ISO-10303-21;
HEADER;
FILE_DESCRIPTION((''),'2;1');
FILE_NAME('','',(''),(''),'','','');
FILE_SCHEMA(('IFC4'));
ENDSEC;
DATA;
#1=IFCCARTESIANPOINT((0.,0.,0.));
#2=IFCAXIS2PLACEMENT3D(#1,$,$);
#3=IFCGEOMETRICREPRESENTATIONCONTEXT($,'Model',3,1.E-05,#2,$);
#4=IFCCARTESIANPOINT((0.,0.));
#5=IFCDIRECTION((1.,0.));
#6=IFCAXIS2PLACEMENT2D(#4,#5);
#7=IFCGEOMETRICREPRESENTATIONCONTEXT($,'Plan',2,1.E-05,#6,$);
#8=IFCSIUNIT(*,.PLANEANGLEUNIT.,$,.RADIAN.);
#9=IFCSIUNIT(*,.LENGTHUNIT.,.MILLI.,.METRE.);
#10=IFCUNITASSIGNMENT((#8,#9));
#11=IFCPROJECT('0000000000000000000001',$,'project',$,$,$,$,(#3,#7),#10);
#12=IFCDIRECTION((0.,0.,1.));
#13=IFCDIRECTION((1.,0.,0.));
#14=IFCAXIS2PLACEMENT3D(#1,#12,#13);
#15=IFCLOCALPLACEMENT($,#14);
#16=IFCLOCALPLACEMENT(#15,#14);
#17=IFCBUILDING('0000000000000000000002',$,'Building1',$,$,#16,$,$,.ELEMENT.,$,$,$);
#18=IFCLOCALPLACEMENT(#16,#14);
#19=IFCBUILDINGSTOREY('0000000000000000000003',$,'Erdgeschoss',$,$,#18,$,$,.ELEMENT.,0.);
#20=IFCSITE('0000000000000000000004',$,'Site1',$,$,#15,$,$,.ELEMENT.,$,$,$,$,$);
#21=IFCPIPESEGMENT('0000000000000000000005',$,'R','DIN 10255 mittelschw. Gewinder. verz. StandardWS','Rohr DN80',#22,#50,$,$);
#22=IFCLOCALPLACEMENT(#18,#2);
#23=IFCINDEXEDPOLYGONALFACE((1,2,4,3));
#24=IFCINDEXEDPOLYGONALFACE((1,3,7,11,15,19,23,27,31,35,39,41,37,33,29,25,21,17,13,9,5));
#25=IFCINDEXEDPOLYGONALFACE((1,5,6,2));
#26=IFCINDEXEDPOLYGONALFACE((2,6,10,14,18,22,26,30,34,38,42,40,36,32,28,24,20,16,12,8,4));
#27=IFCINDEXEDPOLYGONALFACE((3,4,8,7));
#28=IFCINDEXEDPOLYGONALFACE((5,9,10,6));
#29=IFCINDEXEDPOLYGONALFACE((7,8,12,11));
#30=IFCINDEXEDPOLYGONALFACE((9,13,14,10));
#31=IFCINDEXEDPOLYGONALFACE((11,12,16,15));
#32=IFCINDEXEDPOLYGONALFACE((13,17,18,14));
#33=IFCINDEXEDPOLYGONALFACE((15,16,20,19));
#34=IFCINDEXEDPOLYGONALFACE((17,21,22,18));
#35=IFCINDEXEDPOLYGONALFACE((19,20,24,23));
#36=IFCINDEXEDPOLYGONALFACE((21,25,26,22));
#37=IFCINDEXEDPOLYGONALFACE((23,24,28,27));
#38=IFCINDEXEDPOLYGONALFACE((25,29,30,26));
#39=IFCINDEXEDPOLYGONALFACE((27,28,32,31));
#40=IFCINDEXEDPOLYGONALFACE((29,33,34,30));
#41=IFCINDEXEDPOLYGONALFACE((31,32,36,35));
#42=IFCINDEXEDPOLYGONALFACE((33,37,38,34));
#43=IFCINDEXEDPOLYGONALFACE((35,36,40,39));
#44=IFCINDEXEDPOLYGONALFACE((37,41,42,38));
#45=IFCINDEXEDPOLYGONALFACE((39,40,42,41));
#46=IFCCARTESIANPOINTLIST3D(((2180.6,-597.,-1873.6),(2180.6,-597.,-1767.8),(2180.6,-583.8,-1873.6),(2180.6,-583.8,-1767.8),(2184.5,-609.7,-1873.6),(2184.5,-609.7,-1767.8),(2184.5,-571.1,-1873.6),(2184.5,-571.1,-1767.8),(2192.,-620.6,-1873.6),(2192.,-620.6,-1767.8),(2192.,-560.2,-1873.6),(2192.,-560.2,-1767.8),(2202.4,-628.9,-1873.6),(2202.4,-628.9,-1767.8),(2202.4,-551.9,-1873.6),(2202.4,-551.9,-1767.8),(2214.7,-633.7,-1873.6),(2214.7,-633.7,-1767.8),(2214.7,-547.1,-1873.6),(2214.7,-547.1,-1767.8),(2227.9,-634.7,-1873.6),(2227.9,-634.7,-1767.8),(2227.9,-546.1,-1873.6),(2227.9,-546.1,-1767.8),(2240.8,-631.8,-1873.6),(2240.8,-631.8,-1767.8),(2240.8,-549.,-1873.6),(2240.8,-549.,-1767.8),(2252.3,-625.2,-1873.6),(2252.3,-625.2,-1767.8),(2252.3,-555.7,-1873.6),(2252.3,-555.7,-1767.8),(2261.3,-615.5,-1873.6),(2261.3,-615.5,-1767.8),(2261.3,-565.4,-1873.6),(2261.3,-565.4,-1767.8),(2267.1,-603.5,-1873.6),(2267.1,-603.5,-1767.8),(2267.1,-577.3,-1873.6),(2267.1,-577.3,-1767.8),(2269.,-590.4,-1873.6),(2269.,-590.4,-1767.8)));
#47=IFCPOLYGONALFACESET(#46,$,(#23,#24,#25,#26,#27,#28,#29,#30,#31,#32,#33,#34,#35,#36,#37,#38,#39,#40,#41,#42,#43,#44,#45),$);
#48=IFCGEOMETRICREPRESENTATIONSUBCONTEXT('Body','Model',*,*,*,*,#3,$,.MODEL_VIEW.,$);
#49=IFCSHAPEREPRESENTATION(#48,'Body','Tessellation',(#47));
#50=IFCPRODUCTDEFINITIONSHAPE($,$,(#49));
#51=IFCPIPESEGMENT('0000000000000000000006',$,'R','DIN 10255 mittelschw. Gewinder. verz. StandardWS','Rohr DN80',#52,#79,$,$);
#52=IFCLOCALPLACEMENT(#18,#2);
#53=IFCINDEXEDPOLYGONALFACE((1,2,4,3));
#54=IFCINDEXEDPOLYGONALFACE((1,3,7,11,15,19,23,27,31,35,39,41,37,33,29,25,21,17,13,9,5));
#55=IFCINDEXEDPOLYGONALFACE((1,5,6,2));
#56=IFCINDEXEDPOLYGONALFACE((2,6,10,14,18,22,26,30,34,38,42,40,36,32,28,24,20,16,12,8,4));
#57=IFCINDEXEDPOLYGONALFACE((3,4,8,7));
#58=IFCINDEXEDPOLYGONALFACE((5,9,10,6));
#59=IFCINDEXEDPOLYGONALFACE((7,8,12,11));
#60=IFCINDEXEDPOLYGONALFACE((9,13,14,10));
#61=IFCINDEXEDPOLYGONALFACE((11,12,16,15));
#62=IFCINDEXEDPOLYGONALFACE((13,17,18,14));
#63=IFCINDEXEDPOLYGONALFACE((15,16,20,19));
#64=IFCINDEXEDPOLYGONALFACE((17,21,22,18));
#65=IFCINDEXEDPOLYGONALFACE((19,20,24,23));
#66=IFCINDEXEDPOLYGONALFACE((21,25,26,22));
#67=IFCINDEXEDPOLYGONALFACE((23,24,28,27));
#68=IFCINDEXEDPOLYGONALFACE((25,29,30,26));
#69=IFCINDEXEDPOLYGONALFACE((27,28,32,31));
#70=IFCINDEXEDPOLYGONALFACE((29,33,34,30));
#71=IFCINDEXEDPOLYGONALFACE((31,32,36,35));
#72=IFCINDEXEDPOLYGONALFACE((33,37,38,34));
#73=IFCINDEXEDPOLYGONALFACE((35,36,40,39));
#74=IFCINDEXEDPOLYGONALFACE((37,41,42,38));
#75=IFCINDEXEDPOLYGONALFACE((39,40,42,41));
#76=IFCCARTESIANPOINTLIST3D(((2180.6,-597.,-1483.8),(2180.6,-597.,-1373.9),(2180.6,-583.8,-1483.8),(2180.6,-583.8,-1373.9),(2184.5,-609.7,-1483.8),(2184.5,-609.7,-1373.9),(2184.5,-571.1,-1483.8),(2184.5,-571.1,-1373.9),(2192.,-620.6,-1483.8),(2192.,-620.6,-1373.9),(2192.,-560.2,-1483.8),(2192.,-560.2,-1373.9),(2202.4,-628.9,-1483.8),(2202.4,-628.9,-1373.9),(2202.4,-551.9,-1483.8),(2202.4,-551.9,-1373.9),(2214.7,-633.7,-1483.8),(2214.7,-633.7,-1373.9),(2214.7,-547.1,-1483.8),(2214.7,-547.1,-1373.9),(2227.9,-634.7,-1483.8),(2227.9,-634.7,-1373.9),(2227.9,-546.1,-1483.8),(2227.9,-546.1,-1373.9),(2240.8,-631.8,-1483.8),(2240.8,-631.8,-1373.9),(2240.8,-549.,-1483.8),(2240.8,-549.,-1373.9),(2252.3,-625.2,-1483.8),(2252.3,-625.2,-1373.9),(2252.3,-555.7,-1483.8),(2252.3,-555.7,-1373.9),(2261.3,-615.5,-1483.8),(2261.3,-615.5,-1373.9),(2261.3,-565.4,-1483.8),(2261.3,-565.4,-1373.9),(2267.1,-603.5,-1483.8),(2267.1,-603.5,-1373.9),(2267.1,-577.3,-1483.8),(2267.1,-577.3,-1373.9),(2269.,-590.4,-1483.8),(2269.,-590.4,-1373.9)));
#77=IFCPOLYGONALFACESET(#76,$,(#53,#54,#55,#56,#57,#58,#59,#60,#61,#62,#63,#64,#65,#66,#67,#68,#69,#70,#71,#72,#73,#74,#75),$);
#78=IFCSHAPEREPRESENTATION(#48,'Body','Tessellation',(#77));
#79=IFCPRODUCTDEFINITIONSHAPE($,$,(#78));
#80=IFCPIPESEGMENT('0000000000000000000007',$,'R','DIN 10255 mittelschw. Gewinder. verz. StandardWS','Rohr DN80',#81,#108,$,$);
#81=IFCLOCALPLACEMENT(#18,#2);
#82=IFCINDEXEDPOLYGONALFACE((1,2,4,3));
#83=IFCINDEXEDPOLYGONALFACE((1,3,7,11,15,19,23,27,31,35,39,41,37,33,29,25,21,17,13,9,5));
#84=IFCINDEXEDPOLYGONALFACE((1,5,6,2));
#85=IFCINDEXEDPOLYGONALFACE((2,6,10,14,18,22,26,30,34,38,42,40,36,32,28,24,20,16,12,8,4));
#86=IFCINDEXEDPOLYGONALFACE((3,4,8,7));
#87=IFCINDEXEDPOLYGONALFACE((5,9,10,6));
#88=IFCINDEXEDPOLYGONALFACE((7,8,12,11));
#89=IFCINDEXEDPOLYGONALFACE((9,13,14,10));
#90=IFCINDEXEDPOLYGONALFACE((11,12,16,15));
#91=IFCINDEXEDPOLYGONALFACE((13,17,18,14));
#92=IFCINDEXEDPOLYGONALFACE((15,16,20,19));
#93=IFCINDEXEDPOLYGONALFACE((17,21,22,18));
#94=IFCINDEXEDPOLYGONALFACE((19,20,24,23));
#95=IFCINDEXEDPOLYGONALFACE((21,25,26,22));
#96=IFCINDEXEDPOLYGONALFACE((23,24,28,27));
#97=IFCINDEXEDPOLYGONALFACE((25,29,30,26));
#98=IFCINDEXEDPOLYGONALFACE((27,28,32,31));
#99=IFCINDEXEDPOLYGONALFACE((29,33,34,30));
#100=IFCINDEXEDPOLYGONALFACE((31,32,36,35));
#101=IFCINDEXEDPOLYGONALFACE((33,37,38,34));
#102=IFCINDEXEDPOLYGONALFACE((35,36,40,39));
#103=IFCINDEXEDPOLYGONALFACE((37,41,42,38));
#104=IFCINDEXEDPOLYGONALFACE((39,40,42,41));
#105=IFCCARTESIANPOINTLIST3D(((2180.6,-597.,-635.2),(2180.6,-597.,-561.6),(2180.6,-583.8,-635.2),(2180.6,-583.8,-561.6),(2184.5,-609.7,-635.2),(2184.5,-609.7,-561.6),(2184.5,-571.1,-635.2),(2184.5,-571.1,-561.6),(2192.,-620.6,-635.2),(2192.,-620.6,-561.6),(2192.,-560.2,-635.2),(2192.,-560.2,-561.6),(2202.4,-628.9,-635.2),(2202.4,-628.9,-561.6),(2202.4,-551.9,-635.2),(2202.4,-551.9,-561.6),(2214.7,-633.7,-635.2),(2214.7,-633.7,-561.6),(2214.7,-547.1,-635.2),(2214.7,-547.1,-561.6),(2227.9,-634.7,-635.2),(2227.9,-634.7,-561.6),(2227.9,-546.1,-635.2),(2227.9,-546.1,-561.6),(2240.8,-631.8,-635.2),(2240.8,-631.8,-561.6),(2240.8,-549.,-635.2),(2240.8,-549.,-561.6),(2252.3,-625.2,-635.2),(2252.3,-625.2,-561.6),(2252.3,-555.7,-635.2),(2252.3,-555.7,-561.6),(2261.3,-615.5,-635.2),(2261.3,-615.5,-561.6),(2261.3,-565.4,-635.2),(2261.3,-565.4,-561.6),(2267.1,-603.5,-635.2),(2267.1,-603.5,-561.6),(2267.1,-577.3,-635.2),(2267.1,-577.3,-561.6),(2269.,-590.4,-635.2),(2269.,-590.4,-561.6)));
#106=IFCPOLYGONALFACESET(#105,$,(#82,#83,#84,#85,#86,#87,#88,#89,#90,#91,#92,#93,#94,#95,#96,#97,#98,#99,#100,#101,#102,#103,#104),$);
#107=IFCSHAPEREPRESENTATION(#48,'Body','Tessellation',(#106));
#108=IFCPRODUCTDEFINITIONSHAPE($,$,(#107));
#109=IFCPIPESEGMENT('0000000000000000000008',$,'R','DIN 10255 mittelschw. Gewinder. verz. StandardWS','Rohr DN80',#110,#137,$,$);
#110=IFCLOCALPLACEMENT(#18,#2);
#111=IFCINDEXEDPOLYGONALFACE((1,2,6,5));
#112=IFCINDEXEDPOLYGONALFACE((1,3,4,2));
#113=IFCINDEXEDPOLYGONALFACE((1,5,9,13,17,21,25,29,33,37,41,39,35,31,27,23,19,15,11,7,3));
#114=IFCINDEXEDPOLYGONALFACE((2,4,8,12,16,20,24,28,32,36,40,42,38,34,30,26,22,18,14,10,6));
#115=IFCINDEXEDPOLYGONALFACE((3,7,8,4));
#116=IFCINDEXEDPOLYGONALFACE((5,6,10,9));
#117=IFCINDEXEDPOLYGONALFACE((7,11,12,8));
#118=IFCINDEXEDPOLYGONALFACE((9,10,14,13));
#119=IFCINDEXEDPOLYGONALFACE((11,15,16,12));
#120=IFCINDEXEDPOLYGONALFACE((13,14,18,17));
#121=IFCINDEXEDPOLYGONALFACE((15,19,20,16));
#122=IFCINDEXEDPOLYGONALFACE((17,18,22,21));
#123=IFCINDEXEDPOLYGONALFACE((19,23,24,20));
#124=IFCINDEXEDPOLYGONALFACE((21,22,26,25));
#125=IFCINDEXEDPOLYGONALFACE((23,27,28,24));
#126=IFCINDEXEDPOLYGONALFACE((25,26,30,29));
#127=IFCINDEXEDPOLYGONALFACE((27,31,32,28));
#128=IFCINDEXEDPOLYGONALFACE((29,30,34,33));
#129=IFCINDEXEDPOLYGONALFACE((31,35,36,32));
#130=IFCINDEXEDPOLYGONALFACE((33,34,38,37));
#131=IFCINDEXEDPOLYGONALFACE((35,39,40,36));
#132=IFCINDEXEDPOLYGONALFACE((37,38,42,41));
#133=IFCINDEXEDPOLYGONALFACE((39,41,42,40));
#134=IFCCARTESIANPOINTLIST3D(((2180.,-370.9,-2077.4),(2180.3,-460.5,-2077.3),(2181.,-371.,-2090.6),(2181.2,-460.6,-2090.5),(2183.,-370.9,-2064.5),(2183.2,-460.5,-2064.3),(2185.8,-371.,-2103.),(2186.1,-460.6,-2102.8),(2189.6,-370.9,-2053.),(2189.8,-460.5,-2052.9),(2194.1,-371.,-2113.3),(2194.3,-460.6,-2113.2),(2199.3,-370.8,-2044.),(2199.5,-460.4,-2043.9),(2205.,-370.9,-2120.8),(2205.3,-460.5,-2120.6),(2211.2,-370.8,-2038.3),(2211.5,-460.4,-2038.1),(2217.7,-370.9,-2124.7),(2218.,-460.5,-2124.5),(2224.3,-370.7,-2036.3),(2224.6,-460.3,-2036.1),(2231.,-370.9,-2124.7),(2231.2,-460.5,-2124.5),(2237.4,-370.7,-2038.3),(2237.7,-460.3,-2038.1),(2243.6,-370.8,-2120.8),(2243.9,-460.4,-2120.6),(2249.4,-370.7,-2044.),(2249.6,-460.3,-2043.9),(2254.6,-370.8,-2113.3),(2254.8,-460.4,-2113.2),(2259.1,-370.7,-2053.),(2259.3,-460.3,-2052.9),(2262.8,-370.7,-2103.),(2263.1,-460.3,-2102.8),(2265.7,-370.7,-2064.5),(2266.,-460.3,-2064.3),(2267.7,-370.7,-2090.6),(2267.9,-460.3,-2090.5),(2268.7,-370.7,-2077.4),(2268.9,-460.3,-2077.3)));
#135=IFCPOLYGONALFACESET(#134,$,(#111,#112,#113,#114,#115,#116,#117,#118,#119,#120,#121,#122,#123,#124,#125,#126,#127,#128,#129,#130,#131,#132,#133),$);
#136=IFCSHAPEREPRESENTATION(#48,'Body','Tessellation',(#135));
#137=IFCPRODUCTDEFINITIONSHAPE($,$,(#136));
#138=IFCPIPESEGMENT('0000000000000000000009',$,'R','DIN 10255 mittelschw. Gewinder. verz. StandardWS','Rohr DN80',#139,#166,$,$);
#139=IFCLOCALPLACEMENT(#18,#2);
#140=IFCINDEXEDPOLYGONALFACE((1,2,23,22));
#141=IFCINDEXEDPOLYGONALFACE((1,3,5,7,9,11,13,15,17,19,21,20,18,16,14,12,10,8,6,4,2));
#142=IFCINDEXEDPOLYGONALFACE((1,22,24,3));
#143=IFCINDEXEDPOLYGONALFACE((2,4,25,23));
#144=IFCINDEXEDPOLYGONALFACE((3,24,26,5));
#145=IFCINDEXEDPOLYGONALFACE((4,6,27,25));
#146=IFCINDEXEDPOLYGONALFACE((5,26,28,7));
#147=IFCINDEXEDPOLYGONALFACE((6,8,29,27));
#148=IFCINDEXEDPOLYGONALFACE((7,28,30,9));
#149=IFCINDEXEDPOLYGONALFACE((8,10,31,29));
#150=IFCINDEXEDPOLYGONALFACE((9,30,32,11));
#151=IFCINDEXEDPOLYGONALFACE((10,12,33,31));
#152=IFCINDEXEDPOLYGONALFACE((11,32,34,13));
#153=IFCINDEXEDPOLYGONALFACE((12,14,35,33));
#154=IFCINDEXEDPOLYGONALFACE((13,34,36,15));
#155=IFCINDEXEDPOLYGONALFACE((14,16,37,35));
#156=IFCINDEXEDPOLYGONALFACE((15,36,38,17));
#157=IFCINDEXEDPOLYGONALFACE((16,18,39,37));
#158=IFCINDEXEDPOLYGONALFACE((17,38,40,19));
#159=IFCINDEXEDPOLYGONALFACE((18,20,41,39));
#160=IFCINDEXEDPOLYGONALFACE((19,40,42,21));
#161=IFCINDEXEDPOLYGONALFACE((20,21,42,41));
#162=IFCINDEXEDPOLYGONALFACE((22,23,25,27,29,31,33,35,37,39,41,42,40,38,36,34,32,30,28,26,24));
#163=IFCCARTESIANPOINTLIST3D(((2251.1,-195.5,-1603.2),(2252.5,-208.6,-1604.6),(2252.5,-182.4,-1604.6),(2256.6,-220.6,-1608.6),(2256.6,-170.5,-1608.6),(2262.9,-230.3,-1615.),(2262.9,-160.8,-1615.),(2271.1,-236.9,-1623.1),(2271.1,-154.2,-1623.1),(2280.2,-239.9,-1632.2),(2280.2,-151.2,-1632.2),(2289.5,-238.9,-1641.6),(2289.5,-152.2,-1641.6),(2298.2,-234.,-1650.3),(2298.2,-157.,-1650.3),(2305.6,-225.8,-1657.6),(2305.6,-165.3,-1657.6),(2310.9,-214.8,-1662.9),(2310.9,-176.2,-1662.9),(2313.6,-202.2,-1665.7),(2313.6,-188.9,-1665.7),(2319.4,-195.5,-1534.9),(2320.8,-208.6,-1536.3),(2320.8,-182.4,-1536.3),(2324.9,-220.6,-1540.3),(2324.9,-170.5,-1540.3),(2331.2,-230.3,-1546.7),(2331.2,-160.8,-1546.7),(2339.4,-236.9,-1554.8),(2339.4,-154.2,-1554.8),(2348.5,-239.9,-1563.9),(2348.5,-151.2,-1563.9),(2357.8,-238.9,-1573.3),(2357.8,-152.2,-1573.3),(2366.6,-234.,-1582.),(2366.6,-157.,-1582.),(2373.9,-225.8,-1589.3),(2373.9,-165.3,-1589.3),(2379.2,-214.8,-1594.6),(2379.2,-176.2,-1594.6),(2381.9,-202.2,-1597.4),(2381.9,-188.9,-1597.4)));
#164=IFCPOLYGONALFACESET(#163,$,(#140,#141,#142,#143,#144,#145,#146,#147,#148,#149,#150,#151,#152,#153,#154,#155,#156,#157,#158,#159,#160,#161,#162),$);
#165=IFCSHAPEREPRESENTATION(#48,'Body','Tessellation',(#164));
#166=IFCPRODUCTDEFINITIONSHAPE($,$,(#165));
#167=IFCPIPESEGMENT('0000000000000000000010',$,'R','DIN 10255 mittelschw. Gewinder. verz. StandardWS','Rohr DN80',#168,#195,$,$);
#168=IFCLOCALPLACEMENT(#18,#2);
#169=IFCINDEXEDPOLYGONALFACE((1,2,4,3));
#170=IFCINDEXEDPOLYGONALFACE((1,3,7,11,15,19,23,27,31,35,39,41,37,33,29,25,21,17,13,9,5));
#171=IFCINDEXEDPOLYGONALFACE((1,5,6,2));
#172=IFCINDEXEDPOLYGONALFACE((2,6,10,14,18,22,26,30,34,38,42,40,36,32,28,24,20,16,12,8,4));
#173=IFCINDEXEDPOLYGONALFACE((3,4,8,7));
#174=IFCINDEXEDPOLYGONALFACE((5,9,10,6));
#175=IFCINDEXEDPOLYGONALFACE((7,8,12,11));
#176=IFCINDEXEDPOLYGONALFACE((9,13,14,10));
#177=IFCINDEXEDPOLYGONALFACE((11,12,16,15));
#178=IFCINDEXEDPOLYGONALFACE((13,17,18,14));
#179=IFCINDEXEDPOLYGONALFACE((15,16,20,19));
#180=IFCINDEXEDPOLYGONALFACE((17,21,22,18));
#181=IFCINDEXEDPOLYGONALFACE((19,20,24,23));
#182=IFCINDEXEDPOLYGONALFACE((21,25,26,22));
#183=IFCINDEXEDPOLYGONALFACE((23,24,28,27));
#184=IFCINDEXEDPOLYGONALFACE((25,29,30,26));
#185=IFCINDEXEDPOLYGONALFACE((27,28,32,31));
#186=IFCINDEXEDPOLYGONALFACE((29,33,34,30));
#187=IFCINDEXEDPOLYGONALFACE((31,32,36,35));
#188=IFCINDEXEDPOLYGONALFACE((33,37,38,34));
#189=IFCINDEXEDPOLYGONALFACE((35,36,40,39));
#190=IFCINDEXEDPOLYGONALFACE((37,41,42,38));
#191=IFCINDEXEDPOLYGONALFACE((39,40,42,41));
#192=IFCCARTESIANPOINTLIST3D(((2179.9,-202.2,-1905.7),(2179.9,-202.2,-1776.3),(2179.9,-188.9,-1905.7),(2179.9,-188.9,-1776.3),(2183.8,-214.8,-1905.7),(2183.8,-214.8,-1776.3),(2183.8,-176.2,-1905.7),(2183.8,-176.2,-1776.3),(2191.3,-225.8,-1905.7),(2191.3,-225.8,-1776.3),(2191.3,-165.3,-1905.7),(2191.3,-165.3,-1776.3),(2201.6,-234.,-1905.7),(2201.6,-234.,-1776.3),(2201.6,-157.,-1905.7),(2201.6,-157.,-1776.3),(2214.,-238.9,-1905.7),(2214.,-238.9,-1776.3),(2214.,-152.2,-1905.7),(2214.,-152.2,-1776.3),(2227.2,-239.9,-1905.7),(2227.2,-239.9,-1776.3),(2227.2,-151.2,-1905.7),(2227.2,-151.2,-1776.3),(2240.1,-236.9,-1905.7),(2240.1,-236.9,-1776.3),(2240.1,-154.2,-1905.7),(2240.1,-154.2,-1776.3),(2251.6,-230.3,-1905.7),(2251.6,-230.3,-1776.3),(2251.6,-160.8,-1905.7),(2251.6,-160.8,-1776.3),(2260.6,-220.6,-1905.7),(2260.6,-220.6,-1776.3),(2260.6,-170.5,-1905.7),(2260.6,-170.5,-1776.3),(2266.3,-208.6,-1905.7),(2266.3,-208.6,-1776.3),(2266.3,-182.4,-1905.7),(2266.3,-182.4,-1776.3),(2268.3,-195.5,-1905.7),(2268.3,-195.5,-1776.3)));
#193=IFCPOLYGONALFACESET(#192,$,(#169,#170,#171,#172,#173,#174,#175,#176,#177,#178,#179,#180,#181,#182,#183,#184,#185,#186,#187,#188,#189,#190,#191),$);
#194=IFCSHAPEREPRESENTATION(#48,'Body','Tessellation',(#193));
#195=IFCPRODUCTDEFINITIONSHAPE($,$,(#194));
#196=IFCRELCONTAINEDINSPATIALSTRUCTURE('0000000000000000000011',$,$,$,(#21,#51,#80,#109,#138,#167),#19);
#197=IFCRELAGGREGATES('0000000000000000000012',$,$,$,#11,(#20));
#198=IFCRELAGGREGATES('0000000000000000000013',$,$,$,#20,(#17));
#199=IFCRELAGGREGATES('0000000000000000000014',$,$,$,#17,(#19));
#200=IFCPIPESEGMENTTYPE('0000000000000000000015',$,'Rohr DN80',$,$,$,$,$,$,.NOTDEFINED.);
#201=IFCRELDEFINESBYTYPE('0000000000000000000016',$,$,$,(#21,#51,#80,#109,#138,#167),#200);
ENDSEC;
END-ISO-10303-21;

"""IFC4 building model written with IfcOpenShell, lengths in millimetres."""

from ifc_helpers import new_model, si_unit, frame, origin, origin_with_axes, origin_2d_with_axis, place, context, subcontext, project, spatial, circle, extrude, type_object, element, save


model = new_model("IFC4")

# Units and contexts
model_context = context("Model", 3, precision=1e-05, world=origin())
plan_context = context("Plan", 2, precision=1e-05, world=origin_2d_with_axis())
body_context = subcontext(model_context, "Body", "Model", "MODEL_VIEW")
ifc_project = project(units=[si_unit("PLANEANGLEUNIT", "RADIAN"), si_unit("LENGTHUNIT", "METRE", prefix="MILLI")], contexts=[model_context, plan_context])

# Site, building, storey
site_placement = place(None, origin_with_axes())
site = spatial("IfcSite", under=ifc_project, at=site_placement, Name="Site1", CompositionType="ELEMENT")
building_placement = place(site_placement, origin_with_axes())
building = spatial("IfcBuilding", under=site, at=building_placement, Name="Building1", CompositionType="ELEMENT")
storey_placement = place(building_placement, origin_with_axes())
storey = spatial("IfcBuildingStorey", under=building, at=storey_placement, Name="Erdgeschoss", CompositionType="ELEMENT", Elevation=0.0)

# Pipe segments
pipe_segment_type_1 = type_object("IfcPipeSegmentType", Name="Rohr DN80", PredefinedType="NOTDEFINED")
pipe_segment_1_placement = place(storey_placement, frame((2224.6, -590.6, -1820.7), z_axis=(0.0, 0.0, 1.0), x_axis=(1.0, 0.0, 0.0)))
element("IfcPipeSegment", 1, at=pipe_segment_1_placement, inside=storey, type_object=pipe_segment_type_1, Name="R", Description="DIN 10255 mittelschw. Gewinder. verz. StandardWS", ObjectType="Rohr DN80", context=body_context, shape_type="SolidModel", body=[
    extrude(circle(Radius=44.5, at=origin_2d_with_axis()), frame((0.0, 0.1, -52.9), z_axis=(0.0, 0.0, 1.0), x_axis=(1.0, 0.0, 0.0)), (0.0, 0.0, 1.0), 105.8),
])
pipe_segment_2_placement = place(storey_placement, frame((2224.6, -590.6, -1428.8), z_axis=(0.0, 0.0, 1.0), x_axis=(1.0, 0.0, 0.0)))
element("IfcPipeSegment", 2, at=pipe_segment_2_placement, inside=storey, type_object=pipe_segment_type_1, Name="R", Description="DIN 10255 mittelschw. Gewinder. verz. StandardWS", ObjectType="Rohr DN80", context=body_context, shape_type="SolidModel", body=[
    extrude(circle(Radius=44.5, at=origin_2d_with_axis()), frame((0.0, 0.1, -55.0), z_axis=(0.0, 0.0, 1.0), x_axis=(1.0, 0.0, 0.0)), (0.0, 0.0, 1.0), 109.9),
])
pipe_segment_3_placement = place(storey_placement, frame((2224.6, -590.6, -598.4), z_axis=(0.0, 0.0, 1.0), x_axis=(1.0, 0.0, 0.0)))
element("IfcPipeSegment", 3, at=pipe_segment_3_placement, inside=storey, type_object=pipe_segment_type_1, Name="R", Description="DIN 10255 mittelschw. Gewinder. verz. StandardWS", ObjectType="Rohr DN80", context=body_context, shape_type="SolidModel", body=[
    extrude(circle(Radius=44.5, at=origin_2d_with_axis()), frame((0.0, 0.1, -36.8), z_axis=(0.0, 0.0, 1.0), x_axis=(1.0, 0.0, 0.0)), (0.0, 0.0, 1.0), 73.6),
])
pipe_segment_4_placement = place(storey_placement, frame((2224.6, -415.6, -2080.7), z_axis=(0.0, 0.0, 1.0), x_axis=(1.0, 0.0, 0.0)))
element("IfcPipeSegment", 4, at=pipe_segment_4_placement, inside=storey, type_object=pipe_segment_type_1, Name="R", Description="DIN 10255 mittelschw. Gewinder. verz. StandardWS", ObjectType="Rohr DN80", context=body_context, shape_type="SolidModel", body=[
    extrude(circle(Radius=44.5, at=origin_2d_with_axis()), frame((-0.3, 44.8, -0.1), z_axis=(0.002779, -0.999995, 0.001637), x_axis=(0.0, 0.0, 1.0)), (0.0, 0.0, 1.0), 89.6),
])
pipe_segment_5_placement = place(storey_placement, frame((2316.7, -195.7, -1600.4), z_axis=(0.0, 0.0, 1.0), x_axis=(1.0, 0.0, 0.0)))
element("IfcPipeSegment", 5, at=pipe_segment_5_placement, inside=storey, type_object=pipe_segment_type_1, Name="R", Description="DIN 10255 mittelschw. Gewinder. verz. StandardWS", ObjectType="Rohr DN80", context=body_context, shape_type="SolidModel", body=[
    extrude(circle(Radius=44.5, at=origin_2d_with_axis()), frame((34.2, 0.2, 34.2), z_axis=(-0.707107, 0.0, -0.707107), x_axis=(0.0, 0.0, 1.0)), (0.0, 0.0, 1.0), 96.6),
])
pipe_segment_6_placement = place(storey_placement, frame((2223.8, -195.7, -1841.0), z_axis=(0.0, 0.0, 1.0), x_axis=(1.0, 0.0, 0.0)))
element("IfcPipeSegment", 6, at=pipe_segment_6_placement, inside=storey, type_object=pipe_segment_type_1, Name="R", Description="DIN 10255 mittelschw. Gewinder. verz. StandardWS", ObjectType="Rohr DN80", context=body_context, shape_type="SolidModel", body=[
    extrude(circle(Radius=44.5, at=origin_2d_with_axis()), frame((0.0, 0.1, -64.7), z_axis=(0.0, 0.0, 1.0), x_axis=(1.0, 0.0, 0.0)), (0.0, 0.0, 1.0), 129.4),
])

save(model, "model.ifc")
